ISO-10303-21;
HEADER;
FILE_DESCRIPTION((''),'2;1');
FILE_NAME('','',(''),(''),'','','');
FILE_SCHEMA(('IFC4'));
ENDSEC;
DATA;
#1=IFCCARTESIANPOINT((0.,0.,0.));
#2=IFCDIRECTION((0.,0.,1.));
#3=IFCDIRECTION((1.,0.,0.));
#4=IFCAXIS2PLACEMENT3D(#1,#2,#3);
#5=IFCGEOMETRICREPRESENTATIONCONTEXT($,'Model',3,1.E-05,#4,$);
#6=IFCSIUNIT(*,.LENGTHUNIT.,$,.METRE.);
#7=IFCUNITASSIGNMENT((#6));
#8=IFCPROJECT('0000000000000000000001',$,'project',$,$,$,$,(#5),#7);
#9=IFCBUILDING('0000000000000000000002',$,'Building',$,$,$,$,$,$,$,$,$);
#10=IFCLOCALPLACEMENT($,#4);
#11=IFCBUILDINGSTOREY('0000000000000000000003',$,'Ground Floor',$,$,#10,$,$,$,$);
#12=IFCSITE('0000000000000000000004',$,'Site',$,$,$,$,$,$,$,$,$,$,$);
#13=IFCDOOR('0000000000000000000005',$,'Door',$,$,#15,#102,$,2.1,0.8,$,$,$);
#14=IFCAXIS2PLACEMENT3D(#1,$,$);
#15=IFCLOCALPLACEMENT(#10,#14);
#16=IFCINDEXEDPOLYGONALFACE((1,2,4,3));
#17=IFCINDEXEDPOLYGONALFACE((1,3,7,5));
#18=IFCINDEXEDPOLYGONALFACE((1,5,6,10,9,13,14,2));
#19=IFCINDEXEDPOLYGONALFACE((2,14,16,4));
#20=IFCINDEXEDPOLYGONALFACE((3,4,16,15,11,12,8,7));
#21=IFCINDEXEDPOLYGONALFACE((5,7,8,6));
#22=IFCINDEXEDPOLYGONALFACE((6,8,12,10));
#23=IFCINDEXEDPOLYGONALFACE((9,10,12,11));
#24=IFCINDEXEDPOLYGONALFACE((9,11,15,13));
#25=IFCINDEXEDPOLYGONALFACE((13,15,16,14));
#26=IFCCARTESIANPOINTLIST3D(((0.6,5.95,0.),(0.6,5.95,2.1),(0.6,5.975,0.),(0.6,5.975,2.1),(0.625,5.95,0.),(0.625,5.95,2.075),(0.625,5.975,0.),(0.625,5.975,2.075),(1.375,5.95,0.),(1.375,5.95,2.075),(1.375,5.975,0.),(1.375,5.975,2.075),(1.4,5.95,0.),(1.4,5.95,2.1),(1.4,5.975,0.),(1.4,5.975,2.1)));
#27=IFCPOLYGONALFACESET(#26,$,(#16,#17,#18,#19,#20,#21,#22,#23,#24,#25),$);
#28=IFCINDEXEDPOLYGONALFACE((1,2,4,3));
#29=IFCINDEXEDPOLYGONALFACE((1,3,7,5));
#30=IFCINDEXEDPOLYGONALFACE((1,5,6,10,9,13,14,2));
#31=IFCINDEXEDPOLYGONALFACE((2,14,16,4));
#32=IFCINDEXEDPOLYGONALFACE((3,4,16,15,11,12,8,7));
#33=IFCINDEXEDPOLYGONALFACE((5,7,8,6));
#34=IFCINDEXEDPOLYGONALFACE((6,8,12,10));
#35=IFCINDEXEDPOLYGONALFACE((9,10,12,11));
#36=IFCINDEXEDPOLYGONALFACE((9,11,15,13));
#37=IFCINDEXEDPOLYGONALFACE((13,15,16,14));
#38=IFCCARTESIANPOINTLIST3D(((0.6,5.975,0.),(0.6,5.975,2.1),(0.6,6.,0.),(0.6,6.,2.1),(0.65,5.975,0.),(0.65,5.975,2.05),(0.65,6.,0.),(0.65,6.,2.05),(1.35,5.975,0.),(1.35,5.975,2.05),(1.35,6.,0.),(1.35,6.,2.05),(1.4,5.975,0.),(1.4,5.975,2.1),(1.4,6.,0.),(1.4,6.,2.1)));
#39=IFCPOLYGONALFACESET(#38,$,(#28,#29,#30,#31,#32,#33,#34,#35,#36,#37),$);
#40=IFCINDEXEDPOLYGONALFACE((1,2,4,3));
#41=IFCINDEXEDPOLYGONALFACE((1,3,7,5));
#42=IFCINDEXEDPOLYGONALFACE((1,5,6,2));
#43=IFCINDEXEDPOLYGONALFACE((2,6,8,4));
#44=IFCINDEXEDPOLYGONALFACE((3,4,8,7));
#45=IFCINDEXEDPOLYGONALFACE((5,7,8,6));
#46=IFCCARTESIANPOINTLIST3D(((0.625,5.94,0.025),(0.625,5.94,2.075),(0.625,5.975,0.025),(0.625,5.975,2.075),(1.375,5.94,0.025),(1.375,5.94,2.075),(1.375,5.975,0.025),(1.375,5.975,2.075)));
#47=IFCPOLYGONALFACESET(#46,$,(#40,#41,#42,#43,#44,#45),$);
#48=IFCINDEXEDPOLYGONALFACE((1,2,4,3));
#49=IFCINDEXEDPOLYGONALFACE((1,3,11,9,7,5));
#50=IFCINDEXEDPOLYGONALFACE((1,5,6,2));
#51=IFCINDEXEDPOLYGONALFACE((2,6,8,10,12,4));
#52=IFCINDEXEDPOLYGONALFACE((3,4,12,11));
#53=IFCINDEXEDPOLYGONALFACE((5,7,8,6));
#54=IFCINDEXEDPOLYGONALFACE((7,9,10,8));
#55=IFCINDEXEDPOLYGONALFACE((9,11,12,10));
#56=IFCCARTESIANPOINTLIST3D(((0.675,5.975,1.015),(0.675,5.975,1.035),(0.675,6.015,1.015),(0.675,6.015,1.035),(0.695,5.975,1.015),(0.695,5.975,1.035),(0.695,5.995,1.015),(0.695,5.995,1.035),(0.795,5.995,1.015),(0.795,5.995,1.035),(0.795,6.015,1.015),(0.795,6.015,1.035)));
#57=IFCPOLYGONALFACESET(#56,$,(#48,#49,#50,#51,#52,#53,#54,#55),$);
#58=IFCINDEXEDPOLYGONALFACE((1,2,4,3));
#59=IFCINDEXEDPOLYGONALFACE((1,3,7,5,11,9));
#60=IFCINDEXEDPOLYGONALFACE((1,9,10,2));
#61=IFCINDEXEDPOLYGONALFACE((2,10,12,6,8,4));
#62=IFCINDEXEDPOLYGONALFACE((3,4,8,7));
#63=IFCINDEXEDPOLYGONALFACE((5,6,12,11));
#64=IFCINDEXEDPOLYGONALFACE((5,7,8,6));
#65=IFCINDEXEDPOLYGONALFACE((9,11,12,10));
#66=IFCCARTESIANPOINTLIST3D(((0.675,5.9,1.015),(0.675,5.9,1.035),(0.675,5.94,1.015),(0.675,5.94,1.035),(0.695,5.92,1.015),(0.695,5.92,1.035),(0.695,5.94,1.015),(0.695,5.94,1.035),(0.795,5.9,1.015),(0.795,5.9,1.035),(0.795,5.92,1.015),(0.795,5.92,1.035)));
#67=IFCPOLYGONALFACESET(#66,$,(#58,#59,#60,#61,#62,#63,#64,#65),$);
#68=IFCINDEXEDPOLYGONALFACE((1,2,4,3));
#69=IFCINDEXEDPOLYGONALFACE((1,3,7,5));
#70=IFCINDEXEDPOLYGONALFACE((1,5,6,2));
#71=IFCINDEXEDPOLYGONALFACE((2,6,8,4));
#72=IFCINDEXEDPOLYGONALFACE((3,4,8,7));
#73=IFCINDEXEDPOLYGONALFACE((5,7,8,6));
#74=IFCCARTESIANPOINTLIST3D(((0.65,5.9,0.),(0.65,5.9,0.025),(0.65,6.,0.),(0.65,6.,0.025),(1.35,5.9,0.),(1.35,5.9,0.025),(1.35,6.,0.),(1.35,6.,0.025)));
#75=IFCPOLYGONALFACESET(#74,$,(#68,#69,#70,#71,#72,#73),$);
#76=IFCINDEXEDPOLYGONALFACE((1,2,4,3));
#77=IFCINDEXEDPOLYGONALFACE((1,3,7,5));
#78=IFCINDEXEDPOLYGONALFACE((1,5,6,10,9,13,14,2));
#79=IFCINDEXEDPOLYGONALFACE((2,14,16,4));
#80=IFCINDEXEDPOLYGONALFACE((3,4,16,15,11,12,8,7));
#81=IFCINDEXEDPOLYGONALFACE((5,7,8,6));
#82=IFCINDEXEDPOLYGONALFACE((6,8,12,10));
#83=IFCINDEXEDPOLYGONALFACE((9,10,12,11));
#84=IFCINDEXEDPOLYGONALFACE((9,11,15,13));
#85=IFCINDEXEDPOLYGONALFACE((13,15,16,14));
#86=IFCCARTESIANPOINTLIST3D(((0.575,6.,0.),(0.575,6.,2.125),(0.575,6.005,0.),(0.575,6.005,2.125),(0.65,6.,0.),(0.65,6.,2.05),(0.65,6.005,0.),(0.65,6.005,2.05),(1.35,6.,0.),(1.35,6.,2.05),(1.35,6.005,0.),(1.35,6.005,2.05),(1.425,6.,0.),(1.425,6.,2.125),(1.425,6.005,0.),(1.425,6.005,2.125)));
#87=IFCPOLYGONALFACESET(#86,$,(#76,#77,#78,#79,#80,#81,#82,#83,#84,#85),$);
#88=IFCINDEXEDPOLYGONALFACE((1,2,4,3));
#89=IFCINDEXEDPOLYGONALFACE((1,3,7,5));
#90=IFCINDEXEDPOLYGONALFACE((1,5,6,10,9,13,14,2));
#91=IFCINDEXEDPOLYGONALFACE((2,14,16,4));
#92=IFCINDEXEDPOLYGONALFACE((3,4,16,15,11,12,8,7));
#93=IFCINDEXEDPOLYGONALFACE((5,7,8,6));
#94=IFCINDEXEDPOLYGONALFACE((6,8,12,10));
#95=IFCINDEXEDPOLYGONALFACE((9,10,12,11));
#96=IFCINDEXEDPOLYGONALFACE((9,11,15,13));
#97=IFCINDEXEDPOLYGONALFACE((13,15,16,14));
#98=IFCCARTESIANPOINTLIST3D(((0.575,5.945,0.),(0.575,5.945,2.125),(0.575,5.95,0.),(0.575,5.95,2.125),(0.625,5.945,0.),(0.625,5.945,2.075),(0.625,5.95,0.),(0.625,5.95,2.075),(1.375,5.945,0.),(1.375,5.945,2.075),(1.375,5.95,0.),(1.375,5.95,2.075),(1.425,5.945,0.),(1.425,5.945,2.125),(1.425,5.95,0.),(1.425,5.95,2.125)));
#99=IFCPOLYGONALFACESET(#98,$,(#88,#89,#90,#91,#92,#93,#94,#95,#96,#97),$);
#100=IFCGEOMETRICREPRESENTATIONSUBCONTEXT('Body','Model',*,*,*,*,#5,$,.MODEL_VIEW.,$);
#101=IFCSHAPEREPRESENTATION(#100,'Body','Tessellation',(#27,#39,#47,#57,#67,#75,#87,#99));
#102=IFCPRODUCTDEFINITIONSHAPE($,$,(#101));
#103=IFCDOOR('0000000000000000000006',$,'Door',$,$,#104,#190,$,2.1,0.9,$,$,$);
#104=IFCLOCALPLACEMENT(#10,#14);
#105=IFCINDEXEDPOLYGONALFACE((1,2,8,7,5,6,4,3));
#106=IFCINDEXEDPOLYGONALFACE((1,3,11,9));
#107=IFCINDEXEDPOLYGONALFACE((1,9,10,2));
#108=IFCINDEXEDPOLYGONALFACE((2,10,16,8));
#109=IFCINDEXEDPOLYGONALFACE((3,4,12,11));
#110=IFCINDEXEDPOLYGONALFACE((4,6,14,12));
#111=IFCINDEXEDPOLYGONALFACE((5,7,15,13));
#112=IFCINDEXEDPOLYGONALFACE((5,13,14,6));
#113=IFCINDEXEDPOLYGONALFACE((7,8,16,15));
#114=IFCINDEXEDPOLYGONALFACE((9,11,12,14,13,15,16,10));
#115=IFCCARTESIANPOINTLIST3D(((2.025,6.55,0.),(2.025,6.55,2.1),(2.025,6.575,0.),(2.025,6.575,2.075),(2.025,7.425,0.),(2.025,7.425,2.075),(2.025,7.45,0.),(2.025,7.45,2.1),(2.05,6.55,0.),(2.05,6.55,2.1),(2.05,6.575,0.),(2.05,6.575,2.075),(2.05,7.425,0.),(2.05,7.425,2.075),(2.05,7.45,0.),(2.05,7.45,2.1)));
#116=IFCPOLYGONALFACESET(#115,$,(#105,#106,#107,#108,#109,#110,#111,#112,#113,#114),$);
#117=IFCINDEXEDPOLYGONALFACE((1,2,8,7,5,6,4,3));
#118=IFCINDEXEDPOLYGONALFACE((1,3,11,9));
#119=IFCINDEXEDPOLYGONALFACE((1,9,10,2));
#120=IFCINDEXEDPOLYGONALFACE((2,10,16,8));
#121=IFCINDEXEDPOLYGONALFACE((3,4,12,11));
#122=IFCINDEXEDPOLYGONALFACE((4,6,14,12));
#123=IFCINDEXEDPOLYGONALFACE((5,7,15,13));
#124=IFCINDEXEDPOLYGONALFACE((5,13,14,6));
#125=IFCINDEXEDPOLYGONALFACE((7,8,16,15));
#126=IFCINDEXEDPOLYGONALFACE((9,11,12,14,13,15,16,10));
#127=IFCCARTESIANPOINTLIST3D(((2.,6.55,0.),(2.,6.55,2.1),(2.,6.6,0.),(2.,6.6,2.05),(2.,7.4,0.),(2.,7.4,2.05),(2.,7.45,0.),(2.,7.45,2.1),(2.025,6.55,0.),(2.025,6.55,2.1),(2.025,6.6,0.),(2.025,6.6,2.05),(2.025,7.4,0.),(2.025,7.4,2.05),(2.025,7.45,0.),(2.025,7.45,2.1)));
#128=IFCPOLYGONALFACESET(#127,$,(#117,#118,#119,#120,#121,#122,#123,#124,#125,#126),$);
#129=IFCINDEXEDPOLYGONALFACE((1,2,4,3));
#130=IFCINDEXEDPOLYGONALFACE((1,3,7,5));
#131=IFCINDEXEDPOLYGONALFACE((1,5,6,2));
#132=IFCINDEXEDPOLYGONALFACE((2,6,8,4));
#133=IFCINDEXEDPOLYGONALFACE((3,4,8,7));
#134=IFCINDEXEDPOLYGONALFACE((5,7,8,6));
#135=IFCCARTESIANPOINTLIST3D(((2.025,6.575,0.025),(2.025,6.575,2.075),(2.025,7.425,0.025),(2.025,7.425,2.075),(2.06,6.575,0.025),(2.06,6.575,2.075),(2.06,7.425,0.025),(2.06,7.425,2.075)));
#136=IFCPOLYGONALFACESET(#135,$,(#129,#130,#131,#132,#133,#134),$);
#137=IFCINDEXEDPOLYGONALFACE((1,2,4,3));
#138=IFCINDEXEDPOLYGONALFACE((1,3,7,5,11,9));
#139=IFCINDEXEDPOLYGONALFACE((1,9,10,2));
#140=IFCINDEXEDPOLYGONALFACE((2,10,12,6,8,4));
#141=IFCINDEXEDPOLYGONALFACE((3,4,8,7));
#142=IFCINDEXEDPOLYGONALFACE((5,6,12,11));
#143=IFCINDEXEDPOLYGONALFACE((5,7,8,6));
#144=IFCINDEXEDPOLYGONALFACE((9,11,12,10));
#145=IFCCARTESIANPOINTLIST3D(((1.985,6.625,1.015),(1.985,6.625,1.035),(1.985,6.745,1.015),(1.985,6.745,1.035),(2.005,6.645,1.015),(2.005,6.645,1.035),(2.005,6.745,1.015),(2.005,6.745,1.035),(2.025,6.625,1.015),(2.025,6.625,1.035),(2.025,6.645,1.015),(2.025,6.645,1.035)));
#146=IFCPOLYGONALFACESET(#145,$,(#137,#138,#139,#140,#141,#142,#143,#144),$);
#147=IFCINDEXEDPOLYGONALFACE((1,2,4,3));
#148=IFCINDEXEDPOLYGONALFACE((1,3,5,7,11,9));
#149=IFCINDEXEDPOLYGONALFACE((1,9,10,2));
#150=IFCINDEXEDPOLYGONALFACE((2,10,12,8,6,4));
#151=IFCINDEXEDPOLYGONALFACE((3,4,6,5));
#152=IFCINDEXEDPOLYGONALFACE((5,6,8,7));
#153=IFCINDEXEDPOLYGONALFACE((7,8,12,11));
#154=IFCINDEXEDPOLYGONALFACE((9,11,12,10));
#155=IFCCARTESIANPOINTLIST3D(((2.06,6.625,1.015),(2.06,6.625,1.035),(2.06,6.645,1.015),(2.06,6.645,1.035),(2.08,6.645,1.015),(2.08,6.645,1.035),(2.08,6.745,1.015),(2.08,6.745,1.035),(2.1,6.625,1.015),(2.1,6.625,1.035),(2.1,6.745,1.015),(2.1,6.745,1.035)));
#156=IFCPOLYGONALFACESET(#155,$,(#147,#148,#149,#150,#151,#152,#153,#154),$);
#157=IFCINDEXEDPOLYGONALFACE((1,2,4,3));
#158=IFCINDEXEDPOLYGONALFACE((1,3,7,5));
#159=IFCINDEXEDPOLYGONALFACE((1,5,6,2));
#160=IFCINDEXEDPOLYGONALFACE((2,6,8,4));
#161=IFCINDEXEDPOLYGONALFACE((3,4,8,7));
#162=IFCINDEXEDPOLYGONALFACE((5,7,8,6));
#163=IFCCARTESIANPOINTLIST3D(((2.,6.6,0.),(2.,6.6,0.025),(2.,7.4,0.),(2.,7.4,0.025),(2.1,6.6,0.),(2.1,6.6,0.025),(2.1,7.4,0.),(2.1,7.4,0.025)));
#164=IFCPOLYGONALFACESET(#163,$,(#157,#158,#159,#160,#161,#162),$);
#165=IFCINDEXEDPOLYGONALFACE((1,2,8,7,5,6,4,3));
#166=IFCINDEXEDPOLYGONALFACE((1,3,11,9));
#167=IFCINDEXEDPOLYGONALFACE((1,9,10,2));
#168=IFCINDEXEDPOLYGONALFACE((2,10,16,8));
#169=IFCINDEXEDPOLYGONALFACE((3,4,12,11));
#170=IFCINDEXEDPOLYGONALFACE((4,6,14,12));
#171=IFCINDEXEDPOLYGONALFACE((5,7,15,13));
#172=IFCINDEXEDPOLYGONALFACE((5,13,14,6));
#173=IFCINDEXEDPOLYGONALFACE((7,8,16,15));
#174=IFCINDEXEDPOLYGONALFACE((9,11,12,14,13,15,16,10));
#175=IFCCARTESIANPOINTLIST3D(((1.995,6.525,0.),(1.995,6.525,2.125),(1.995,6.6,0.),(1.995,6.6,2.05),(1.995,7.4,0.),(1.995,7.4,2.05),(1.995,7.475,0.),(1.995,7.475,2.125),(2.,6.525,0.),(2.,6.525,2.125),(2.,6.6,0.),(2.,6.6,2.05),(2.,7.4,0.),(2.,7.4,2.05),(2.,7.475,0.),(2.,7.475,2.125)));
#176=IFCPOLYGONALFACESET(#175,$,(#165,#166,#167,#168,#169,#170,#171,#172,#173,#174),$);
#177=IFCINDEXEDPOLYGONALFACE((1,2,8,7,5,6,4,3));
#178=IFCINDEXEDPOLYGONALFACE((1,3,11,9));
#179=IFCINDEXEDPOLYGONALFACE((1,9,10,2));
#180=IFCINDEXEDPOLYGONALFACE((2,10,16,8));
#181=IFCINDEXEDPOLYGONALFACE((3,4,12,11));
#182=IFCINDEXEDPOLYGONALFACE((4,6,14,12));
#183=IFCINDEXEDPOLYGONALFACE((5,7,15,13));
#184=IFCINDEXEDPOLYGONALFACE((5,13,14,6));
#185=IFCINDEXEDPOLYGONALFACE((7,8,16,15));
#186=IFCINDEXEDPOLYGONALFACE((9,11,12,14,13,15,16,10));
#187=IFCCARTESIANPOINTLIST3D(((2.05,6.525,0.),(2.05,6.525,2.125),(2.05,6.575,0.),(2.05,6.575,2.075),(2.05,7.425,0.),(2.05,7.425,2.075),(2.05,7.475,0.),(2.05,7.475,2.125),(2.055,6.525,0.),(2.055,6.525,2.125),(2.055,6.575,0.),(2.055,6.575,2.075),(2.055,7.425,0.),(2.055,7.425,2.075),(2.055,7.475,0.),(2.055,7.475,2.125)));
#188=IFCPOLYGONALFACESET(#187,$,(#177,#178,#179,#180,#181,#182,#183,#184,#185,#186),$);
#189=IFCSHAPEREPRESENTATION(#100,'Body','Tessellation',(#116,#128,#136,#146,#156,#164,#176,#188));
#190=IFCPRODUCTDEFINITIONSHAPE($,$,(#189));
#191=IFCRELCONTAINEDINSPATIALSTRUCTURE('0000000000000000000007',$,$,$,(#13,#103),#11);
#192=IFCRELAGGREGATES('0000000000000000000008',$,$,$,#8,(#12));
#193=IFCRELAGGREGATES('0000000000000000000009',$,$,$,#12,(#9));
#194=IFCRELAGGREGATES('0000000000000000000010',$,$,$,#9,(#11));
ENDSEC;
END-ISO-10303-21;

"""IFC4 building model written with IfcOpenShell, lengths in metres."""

from ifc_helpers import new_model, si_unit, frame, origin_with_axes, place, context, subcontext, project, spatial, line, indexed_curve, outline, extrude, element, save


model = new_model("IFC4")

# Units and contexts
model_context = context("Model", 3, precision=1e-05, world=origin_with_axes())
body_context = subcontext(model_context, "Body", "Model", "MODEL_VIEW")
ifc_project = project(units=[si_unit("LENGTHUNIT", "METRE")], contexts=[model_context])

# Site, building, storey
site = spatial("IfcSite", under=ifc_project, Name="Site")
building = spatial("IfcBuilding", under=site, Name="Building")
storey_placement = place(None, origin_with_axes())
storey = spatial("IfcBuildingStorey", under=building, at=storey_placement, Name="Ground Floor")

# Doors
door_1_placement = place(storey_placement, frame((1.4, 6.0, 0.0), z_axis=(0.0, 0.0, 1.0), x_axis=(-1.0, 0.0, 0.0)))
element("IfcDoor", 1, at=door_1_placement, inside=storey, Name="Door", OverallHeight=2.1, OverallWidth=0.8, context=body_context, shape_type="SweptSolid", body=[
    extrude(outline(indexed_curve([(0.0, 0.0), (0.0, 2.1), (0.8, 2.1), (0.8, 0.0), (0.775, 0.0), (0.775, 2.075), (0.025, 2.075), (0.025, 0.0)], segments=[line(1, 2, 3, 4, 5, 6, 7, 8, 1)])), frame((0.0, 0.025, 0.0), z_axis=(0.0, -1.0, 0.0), x_axis=(1.0, 0.0, 0.0)), (0.0, 0.0, -1.0), 0.025),
    extrude(outline(indexed_curve([(0.0, 0.0), (0.0, 2.1), (0.8, 2.1), (0.8, 0.0), (0.75, 0.0), (0.75, 2.05), (0.05, 2.05), (0.05, 0.0)], segments=[line(1, 2, 3, 4, 5, 6, 7, 8, 1)])), frame((0.0, 0.0, 0.0), z_axis=(0.0, -1.0, 0.0), x_axis=(1.0, 0.0, 0.0)), (0.0, 0.0, -1.0), 0.025),
    extrude(outline(indexed_curve([(0.0, 0.0), (0.75, 0.0), (0.75, 0.035), (0.0, 0.035)], segments=[line(1, 2, 3, 4, 1)])), frame((0.025, 0.025, 0.025), z_axis=(0.0, 0.0, 1.0), x_axis=(1.0, 0.0, 0.0)), (0.0, 0.0, 1.0), 2.05),
    extrude(outline(indexed_curve([(0.0, 0.0), (0.0, -0.04), (-0.12, -0.04), (-0.12, -0.02), (-0.02, -0.02), (-0.02, 0.0)], segments=[line(1, 2, 3, 4, 5, 6, 1)])), frame((0.725, 0.025, 1.015), z_axis=(0.0, 0.0, 1.0), x_axis=(1.0, 0.0, 0.0)), (0.0, 0.0, 1.0), 0.02),
    extrude(outline(indexed_curve([(0.0, 0.0), (0.0, 0.04), (-0.12, 0.04), (-0.12, 0.02), (-0.02, 0.02), (-0.02, 0.0)], segments=[line(1, 2, 3, 4, 5, 6, 1)])), frame((0.725, 0.06, 1.015), z_axis=(0.0, 0.0, 1.0), x_axis=(1.0, 0.0, 0.0)), (0.0, 0.0, 1.0), 0.02),
    extrude(outline(indexed_curve([(0.0, 0.0), (0.7, 0.0), (0.7, 0.1), (0.0, 0.1)], segments=[line(1, 2, 3, 4, 1)])), frame((0.05, 0.0, 0.0), z_axis=(0.0, 0.0, 1.0), x_axis=(1.0, 0.0, 0.0)), (0.0, 0.0, 1.0), 0.025),
    extrude(outline(indexed_curve([(0.0, 0.0), (0.0, 2.125), (0.85, 2.125), (0.85, 0.0), (0.775, 0.0), (0.775, 2.05), (0.075, 2.05), (0.075, 0.0)], segments=[line(1, 2, 3, 4, 5, 6, 7, 8, 1)])), frame((-0.025, -0.005, 0.0), z_axis=(0.0, -1.0, 0.0), x_axis=(1.0, 0.0, 0.0)), (0.0, 0.0, -1.0), 0.005),
    extrude(outline(indexed_curve([(0.0, 0.0), (0.0, 2.125), (0.85, 2.125), (0.85, 0.0), (0.8, 0.0), (0.8, 2.075), (0.05, 2.075), (0.05, 0.0)], segments=[line(1, 2, 3, 4, 5, 6, 7, 8, 1)])), frame((-0.025, 0.05, 0.0), z_axis=(0.0, -1.0, 0.0), x_axis=(1.0, 0.0, 0.0)), (0.0, 0.0, -1.0), 0.005),
])
door_2_placement = place(storey_placement, frame((2.0, 7.45, 0.0), z_axis=(0.0, 0.0, 1.0), x_axis=(0.0, -1.0, 0.0)))
element("IfcDoor", 2, at=door_2_placement, inside=storey, Name="Door", OverallHeight=2.1, OverallWidth=0.9, context=body_context, shape_type="SweptSolid", body=[
    extrude(outline(indexed_curve([(0.0, 0.0), (0.0, 2.1), (0.9, 2.1), (0.9, 0.0), (0.875, 0.0), (0.875, 2.075), (0.025, 2.075), (0.025, 0.0)], segments=[line(1, 2, 3, 4, 5, 6, 7, 8, 1)])), frame((0.0, 0.025, 0.0), z_axis=(0.0, -1.0, 0.0), x_axis=(1.0, 0.0, 0.0)), (0.0, 0.0, -1.0), 0.025),
    extrude(outline(indexed_curve([(0.0, 0.0), (0.0, 2.1), (0.9, 2.1), (0.9, 0.0), (0.85, 0.0), (0.85, 2.05), (0.05, 2.05), (0.05, 0.0)], segments=[line(1, 2, 3, 4, 5, 6, 7, 8, 1)])), frame((0.0, 0.0, 0.0), z_axis=(0.0, -1.0, 0.0), x_axis=(1.0, 0.0, 0.0)), (0.0, 0.0, -1.0), 0.025),
    extrude(outline(indexed_curve([(0.0, 0.0), (0.85, 0.0), (0.85, 0.035), (0.0, 0.035)], segments=[line(1, 2, 3, 4, 1)])), frame((0.025, 0.025, 0.025), z_axis=(0.0, 0.0, 1.0), x_axis=(1.0, 0.0, 0.0)), (0.0, 0.0, 1.0), 2.05),
    extrude(outline(indexed_curve([(0.0, 0.0), (0.0, -0.04), (-0.12, -0.04), (-0.12, -0.02), (-0.02, -0.02), (-0.02, 0.0)], segments=[line(1, 2, 3, 4, 5, 6, 1)])), frame((0.825, 0.025, 1.015), z_axis=(0.0, 0.0, 1.0), x_axis=(1.0, 0.0, 0.0)), (0.0, 0.0, 1.0), 0.02),
    extrude(outline(indexed_curve([(0.0, 0.0), (0.0, 0.04), (-0.12, 0.04), (-0.12, 0.02), (-0.02, 0.02), (-0.02, 0.0)], segments=[line(1, 2, 3, 4, 5, 6, 1)])), frame((0.825, 0.06, 1.015), z_axis=(0.0, 0.0, 1.0), x_axis=(1.0, 0.0, 0.0)), (0.0, 0.0, 1.0), 0.02),
    extrude(outline(indexed_curve([(0.0, 0.0), (0.8, 0.0), (0.8, 0.1), (0.0, 0.1)], segments=[line(1, 2, 3, 4, 1)])), frame((0.05, 0.0, 0.0), z_axis=(0.0, 0.0, 1.0), x_axis=(1.0, 0.0, 0.0)), (0.0, 0.0, 1.0), 0.025),
    extrude(outline(indexed_curve([(0.0, 0.0), (0.0, 2.125), (0.95, 2.125), (0.95, 0.0), (0.875, 0.0), (0.875, 2.05), (0.075, 2.05), (0.075, 0.0)], segments=[line(1, 2, 3, 4, 5, 6, 7, 8, 1)])), frame((-0.025, -0.005, 0.0), z_axis=(0.0, -1.0, 0.0), x_axis=(1.0, 0.0, 0.0)), (0.0, 0.0, -1.0), 0.005),
    extrude(outline(indexed_curve([(0.0, 0.0), (0.0, 2.125), (0.95, 2.125), (0.95, 0.0), (0.9, 0.0), (0.9, 2.075), (0.05, 2.075), (0.05, 0.0)], segments=[line(1, 2, 3, 4, 5, 6, 7, 8, 1)])), frame((-0.025, 0.05, 0.0), z_axis=(0.0, -1.0, 0.0), x_axis=(1.0, 0.0, 0.0)), (0.0, 0.0, -1.0), 0.005),
])

save(model, "model.ifc")
